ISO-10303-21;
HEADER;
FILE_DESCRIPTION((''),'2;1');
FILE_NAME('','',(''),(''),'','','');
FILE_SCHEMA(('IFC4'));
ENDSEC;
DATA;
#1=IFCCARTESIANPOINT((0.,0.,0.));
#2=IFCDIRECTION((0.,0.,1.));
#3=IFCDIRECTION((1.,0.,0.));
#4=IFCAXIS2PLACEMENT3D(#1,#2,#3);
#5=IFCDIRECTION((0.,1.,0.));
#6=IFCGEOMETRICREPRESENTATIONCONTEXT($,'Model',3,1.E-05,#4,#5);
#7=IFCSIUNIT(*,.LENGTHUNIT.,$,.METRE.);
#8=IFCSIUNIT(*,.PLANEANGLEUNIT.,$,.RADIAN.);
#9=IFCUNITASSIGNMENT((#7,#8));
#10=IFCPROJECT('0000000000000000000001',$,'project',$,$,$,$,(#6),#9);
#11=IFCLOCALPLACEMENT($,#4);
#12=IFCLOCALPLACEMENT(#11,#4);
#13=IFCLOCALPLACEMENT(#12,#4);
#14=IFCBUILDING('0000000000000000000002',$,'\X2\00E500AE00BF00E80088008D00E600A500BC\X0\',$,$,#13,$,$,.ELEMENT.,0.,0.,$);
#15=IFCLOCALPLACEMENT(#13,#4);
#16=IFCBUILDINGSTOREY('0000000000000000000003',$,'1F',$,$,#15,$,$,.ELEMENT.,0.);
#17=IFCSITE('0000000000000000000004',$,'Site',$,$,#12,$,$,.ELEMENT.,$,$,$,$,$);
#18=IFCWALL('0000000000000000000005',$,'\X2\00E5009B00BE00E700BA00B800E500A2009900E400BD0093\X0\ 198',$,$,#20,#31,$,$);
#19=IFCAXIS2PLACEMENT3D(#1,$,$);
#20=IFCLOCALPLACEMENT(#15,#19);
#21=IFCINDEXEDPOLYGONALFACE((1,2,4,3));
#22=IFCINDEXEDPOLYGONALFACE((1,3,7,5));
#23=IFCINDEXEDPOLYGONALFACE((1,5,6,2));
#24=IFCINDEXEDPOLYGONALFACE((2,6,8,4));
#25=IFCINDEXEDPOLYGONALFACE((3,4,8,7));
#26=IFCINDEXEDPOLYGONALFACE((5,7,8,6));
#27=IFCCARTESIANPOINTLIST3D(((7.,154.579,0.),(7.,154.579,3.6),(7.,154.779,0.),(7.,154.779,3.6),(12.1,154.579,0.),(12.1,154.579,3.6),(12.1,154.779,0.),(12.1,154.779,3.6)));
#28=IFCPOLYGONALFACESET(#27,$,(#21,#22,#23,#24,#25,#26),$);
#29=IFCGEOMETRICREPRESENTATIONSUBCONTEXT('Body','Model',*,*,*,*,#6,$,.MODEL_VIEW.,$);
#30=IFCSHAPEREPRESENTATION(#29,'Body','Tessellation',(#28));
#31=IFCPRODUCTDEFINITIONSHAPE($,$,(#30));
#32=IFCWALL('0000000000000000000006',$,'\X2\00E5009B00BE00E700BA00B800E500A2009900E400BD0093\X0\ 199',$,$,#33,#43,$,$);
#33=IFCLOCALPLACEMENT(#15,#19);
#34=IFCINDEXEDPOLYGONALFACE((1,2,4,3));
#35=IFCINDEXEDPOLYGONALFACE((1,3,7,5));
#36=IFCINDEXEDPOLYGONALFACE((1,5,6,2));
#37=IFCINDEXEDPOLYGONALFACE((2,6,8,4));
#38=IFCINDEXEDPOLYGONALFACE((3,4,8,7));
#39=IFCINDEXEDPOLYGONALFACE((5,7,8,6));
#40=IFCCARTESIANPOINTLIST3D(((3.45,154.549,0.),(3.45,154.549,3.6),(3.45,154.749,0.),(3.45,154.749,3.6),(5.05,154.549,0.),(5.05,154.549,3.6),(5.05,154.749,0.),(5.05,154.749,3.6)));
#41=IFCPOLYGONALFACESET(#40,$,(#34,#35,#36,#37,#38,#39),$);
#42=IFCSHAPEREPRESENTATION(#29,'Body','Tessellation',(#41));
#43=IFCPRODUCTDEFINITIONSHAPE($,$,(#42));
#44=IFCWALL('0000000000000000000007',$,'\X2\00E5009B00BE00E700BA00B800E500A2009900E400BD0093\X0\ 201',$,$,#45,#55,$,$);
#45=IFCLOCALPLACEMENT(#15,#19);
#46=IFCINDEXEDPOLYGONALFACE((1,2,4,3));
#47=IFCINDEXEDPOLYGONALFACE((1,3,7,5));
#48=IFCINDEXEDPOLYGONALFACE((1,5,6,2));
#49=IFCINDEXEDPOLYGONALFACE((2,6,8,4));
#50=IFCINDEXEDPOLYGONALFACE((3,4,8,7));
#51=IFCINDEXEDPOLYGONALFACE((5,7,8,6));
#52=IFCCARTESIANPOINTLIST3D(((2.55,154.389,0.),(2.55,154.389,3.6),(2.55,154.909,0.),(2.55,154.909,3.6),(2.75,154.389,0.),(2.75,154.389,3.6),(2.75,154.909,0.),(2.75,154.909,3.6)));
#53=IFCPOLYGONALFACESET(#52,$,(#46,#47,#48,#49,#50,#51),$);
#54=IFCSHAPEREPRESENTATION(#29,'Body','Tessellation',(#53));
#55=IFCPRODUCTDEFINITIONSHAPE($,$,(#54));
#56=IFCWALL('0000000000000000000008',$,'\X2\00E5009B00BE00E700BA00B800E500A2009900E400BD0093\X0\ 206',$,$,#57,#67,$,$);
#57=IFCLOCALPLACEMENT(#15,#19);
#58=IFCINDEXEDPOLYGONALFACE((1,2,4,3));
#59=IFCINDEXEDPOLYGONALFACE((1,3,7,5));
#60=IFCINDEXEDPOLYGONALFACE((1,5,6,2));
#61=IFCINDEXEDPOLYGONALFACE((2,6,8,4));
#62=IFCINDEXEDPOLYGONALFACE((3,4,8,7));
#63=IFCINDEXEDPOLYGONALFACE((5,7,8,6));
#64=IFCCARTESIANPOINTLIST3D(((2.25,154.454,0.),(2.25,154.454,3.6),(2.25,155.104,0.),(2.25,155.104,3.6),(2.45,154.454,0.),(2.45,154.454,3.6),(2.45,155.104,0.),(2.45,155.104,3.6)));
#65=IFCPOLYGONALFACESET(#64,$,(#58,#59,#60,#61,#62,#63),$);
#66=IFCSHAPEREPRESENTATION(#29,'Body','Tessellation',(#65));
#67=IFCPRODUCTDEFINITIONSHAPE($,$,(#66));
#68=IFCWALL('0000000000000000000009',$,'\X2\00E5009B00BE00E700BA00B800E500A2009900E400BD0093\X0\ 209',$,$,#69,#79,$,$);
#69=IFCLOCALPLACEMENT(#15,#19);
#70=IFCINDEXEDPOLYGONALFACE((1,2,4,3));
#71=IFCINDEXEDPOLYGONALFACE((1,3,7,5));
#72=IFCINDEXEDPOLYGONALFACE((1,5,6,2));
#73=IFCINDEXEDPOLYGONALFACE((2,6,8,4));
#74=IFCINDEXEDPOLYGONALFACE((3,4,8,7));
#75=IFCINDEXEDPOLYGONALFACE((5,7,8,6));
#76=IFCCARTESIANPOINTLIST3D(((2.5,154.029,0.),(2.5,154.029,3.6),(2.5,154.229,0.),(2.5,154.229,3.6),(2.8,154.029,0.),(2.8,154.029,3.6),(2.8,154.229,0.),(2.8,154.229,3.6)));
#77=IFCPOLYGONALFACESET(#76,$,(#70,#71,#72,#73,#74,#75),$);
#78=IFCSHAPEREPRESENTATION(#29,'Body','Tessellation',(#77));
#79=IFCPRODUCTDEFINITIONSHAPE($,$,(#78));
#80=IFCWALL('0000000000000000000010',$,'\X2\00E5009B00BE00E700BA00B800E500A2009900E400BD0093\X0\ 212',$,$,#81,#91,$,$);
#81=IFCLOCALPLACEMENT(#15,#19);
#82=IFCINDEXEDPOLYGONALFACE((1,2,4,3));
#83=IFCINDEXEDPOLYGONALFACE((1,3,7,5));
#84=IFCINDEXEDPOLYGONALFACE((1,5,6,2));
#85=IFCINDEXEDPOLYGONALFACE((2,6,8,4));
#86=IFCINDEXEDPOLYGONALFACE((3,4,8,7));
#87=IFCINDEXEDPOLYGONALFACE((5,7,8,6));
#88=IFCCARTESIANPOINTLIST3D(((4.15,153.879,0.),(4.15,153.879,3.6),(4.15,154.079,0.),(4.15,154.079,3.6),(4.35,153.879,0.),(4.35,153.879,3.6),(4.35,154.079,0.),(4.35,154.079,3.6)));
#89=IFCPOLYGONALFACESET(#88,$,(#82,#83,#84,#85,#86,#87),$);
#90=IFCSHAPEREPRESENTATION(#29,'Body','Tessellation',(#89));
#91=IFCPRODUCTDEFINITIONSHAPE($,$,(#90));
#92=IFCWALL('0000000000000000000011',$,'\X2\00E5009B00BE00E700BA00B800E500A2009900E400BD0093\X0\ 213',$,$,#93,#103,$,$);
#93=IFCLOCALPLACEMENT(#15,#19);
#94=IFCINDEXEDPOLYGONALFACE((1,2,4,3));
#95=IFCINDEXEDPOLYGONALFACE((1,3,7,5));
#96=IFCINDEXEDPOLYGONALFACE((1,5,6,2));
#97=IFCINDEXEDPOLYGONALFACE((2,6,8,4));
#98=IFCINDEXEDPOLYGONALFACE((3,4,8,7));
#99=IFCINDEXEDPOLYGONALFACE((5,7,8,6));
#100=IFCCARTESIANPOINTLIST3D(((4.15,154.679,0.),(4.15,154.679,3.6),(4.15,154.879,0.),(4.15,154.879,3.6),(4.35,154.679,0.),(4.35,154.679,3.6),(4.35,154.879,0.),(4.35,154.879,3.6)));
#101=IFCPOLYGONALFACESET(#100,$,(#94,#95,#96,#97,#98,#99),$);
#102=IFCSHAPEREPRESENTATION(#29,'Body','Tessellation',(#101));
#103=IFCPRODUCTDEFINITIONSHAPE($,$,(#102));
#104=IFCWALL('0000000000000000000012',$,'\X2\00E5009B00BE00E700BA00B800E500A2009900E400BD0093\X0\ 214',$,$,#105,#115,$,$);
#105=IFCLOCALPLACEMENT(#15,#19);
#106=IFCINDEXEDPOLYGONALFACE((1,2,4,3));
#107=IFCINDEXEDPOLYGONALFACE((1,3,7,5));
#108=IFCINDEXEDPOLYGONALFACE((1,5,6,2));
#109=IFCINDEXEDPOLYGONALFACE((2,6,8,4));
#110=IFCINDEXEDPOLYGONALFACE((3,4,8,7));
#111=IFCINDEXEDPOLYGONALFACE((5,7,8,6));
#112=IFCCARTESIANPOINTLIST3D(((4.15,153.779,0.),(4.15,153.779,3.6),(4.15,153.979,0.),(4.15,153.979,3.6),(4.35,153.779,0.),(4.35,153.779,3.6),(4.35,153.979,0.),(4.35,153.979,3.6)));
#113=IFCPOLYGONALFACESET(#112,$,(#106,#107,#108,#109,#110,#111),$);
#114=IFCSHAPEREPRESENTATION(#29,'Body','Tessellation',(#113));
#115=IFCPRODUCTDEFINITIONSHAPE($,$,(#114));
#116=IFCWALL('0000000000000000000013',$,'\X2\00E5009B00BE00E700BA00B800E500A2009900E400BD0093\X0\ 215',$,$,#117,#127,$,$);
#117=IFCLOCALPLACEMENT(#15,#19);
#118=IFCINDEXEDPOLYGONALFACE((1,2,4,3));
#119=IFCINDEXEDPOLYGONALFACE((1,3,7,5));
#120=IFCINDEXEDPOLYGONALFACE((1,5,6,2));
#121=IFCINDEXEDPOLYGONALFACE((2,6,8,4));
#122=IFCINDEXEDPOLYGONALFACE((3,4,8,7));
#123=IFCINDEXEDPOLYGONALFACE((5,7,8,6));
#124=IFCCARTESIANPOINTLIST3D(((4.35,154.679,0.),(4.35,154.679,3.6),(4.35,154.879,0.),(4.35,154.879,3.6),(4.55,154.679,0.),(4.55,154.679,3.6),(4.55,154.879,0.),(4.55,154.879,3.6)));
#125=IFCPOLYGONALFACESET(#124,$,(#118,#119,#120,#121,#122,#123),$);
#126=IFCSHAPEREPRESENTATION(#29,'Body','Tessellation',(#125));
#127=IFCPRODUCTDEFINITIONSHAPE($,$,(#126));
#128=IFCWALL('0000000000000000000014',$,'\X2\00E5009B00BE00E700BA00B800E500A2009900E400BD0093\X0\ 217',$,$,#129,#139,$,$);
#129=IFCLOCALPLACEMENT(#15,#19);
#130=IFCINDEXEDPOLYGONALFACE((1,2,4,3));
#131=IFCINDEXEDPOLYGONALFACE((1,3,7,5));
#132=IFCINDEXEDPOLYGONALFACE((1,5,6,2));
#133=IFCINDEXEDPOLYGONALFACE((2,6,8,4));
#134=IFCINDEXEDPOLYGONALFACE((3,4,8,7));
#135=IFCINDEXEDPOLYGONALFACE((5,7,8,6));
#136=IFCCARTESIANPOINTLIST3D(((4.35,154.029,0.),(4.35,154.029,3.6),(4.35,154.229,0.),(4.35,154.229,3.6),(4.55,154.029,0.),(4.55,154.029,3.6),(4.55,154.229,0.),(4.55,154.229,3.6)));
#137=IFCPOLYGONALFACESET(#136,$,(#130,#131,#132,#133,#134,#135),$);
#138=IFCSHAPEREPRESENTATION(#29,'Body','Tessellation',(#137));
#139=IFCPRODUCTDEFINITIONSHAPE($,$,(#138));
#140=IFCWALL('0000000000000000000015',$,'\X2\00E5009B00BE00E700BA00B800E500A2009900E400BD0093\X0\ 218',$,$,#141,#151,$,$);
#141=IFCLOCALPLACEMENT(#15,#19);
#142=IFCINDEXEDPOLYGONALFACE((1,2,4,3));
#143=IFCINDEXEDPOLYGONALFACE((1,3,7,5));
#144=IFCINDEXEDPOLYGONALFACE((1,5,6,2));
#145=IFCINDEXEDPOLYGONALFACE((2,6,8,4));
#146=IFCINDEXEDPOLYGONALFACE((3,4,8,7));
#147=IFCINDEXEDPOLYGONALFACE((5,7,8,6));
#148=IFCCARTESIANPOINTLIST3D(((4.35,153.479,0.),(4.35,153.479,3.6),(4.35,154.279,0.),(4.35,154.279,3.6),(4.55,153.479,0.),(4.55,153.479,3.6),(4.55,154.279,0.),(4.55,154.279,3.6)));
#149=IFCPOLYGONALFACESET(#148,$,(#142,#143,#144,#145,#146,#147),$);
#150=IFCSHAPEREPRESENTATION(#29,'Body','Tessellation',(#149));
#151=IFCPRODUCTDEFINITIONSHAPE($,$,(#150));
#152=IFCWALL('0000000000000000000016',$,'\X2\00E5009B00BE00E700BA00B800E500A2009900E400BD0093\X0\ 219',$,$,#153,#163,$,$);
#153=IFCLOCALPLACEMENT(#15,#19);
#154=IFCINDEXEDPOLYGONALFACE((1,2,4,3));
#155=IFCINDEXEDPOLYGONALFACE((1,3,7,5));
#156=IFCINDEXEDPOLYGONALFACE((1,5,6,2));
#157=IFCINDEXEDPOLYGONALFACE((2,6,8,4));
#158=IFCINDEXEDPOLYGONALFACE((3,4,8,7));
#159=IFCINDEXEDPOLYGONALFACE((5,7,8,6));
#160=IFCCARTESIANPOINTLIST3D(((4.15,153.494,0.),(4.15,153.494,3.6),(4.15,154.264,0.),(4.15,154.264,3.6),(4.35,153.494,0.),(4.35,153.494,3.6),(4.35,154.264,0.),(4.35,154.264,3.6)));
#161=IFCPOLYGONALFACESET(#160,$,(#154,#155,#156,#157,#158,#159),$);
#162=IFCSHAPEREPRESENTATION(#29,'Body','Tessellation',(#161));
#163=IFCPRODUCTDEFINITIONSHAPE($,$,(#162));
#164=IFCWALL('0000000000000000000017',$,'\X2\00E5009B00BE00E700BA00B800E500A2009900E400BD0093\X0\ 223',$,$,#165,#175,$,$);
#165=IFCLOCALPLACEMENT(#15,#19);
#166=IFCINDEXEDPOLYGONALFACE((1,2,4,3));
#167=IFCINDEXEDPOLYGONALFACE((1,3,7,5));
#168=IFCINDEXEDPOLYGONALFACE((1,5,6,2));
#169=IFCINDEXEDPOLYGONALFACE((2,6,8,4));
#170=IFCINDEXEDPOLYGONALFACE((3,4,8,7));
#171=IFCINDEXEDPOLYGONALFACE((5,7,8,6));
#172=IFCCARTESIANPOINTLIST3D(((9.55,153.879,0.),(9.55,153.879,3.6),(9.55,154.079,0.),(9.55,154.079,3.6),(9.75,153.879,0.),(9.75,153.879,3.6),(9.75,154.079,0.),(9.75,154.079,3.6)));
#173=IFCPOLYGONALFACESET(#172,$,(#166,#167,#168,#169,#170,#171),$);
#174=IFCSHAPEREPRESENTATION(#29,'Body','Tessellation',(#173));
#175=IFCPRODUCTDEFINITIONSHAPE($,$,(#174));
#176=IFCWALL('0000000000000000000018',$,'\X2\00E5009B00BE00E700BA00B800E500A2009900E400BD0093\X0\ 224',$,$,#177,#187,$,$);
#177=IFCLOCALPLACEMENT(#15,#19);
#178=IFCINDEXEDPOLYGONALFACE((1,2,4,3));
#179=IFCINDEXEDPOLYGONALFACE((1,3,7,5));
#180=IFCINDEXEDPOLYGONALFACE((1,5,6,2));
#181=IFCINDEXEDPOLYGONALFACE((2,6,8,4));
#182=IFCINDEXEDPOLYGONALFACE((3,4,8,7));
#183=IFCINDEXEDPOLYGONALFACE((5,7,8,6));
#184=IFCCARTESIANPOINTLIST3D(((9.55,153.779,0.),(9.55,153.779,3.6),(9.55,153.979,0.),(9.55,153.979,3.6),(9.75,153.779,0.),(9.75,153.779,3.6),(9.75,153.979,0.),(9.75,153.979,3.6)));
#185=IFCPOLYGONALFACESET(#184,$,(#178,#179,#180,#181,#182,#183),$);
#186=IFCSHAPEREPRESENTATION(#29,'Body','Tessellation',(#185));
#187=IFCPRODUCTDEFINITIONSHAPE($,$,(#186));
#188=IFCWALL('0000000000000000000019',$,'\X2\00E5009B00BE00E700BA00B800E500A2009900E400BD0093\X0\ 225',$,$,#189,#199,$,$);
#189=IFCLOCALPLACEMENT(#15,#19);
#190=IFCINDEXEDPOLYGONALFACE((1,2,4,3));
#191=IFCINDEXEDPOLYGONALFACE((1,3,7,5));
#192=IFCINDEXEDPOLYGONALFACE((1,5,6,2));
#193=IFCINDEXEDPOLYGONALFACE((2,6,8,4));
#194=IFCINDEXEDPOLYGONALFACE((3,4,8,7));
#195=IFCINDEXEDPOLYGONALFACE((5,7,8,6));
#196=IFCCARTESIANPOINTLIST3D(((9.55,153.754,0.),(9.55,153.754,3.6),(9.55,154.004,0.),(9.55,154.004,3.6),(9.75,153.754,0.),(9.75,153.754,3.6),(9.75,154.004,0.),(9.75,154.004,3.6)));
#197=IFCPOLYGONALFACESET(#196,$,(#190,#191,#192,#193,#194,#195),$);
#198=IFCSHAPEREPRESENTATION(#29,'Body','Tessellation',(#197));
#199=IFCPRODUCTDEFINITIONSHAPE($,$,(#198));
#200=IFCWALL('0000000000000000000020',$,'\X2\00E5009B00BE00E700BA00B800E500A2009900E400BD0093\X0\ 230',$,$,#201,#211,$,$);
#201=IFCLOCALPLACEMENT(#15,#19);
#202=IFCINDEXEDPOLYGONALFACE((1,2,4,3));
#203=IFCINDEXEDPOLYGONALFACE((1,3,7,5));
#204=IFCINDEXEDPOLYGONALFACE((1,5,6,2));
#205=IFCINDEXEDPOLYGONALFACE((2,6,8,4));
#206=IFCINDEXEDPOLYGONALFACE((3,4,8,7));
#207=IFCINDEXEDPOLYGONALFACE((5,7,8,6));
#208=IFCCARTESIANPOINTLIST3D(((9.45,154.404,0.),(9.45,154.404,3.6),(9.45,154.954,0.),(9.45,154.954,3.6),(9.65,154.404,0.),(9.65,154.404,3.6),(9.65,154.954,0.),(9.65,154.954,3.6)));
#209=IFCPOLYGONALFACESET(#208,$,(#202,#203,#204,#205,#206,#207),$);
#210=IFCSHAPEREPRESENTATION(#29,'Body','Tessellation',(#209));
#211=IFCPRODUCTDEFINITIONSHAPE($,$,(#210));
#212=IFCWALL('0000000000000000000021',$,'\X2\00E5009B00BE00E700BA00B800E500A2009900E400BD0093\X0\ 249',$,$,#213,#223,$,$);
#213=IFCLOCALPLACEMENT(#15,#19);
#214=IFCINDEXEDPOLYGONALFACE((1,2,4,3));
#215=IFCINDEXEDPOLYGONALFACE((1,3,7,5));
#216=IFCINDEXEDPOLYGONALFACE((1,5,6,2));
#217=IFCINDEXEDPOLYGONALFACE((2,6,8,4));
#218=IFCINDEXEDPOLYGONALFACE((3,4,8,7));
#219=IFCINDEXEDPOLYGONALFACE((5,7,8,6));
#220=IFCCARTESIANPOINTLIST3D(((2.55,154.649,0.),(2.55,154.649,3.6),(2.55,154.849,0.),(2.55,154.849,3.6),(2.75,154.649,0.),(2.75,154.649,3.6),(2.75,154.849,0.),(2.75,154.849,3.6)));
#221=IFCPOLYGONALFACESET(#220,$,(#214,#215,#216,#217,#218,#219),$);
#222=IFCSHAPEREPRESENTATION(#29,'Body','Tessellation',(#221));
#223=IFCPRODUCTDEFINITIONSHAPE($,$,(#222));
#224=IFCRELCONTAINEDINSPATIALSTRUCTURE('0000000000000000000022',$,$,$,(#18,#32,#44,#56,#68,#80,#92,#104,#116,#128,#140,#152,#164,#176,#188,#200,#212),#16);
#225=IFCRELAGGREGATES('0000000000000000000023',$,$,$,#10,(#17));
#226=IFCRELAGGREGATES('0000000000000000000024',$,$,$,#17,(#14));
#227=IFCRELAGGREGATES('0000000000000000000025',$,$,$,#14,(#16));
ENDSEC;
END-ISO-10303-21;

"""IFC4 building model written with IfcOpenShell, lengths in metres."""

from ifc_helpers import new_model, si_unit, direction, frame, frame_2d, origin_with_axes, place, context, subcontext, project, spatial, rectangle, extrude, element, save


model = new_model("IFC4")

# Units and contexts
model_context = context("Model", 3, precision=1e-05, world=origin_with_axes(), true_north=direction((0.0, 1.0, 0.0)))
body_context = subcontext(model_context, "Body", "Model", "MODEL_VIEW")
ifc_project = project(units=[si_unit("LENGTHUNIT", "METRE"), si_unit("PLANEANGLEUNIT", "RADIAN")], contexts=[model_context])

# Site, building, storey
placement = place(None, origin_with_axes())
site_placement = place(placement, origin_with_axes())
site = spatial("IfcSite", under=ifc_project, at=site_placement, Name="Site", CompositionType="ELEMENT")
building_placement = place(site_placement, origin_with_axes())
building = spatial("IfcBuilding", under=site, at=building_placement, Name="å®¿è\u0088\u008dæ¥¼", CompositionType="ELEMENT", ElevationOfRefHeight=0.0, ElevationOfTerrain=0.0)
storey_placement = place(building_placement, origin_with_axes())
storey = spatial("IfcBuildingStorey", under=building, at=storey_placement, Name="1F", CompositionType="ELEMENT", Elevation=0.0)

# Walls
wall_1_placement = place(storey_placement, frame((9.55, 154.679, 0.0), z_axis=(0.0, 0.0, 1.0), x_axis=(-1.0, 0.0, 0.0)))
element("IfcWall", 1, at=wall_1_placement, inside=storey, Name="å\u009b¾çº¸å¢\u0099ä½\u0093 198", context=body_context, shape_type="SweptSolid", body=[
    extrude(rectangle(XDim=5.1, YDim=0.2, at=frame_2d((0.0, 0.0), x_axis=(1.0, 0.0, 0.0))), frame((0.0, 0.0, 0.0), z_axis=(0.0, 0.0, 1.0)), (0.0, 0.0, 1.0), 3.6),
])
wall_2_placement = place(storey_placement, frame((4.25, 154.649, 0.0), z_axis=(0.0, 0.0, 1.0), x_axis=(-1.0, 0.0, 0.0)))
element("IfcWall", 2, at=wall_2_placement, inside=storey, Name="å\u009b¾çº¸å¢\u0099ä½\u0093 199", context=body_context, shape_type="SweptSolid", body=[
    extrude(rectangle(XDim=1.6, YDim=0.2, at=frame_2d((0.0, 0.0), x_axis=(1.0, 0.0, 0.0))), frame((0.0, 0.0, 0.0), z_axis=(0.0, 0.0, 1.0)), (0.0, 0.0, 1.0), 3.6),
])
wall_3_placement = place(storey_placement, frame((2.65, 154.649, 0.0), z_axis=(0.0, 0.0, 1.0), x_axis=(0.0, -1.0, 0.0)))
element("IfcWall", 3, at=wall_3_placement, inside=storey, Name="å\u009b¾çº¸å¢\u0099ä½\u0093 201", context=body_context, shape_type="SweptSolid", body=[
    extrude(rectangle(XDim=0.52, YDim=0.2, at=frame_2d((0.0, 0.0), x_axis=(1.0, 0.0, 0.0))), frame((0.0, 0.0, 0.0), z_axis=(0.0, 0.0, 1.0)), (0.0, 0.0, 1.0), 3.6),
])
wall_4_placement = place(storey_placement, frame((2.35, 154.779, 0.0), z_axis=(0.0, 0.0, 1.0), x_axis=(0.0, -1.0, 0.0)))
element("IfcWall", 4, at=wall_4_placement, inside=storey, Name="å\u009b¾çº¸å¢\u0099ä½\u0093 206", context=body_context, shape_type="SweptSolid", body=[
    extrude(rectangle(XDim=0.65, YDim=0.2, at=frame_2d((0.0, 0.0), x_axis=(1.0, 0.0, 0.0))), frame((0.0, 0.0, 0.0), z_axis=(0.0, 0.0, 1.0)), (0.0, 0.0, 1.0), 3.6),
])
wall_5_placement = place(storey_placement, frame((2.65, 154.129, 0.0), z_axis=(0.0, 0.0, 1.0), x_axis=(-1.0, 0.0, 0.0)))
element("IfcWall", 5, at=wall_5_placement, inside=storey, Name="å\u009b¾çº¸å¢\u0099ä½\u0093 209", context=body_context, shape_type="SweptSolid", body=[
    extrude(rectangle(XDim=0.3, YDim=0.2, at=frame_2d((0.0, 0.0), x_axis=(1.0, 0.0, 0.0))), frame((0.0, 0.0, 0.0), z_axis=(0.0, 0.0, 1.0)), (0.0, 0.0, 1.0), 3.6),
])
for number, where, z_axis, x_axis, name in (
    (6, (4.25, 153.979, 0.0), (0.0, 0.0, 1.0), (1.0, 0.0, 0.0), "å\u009b¾çº¸å¢\u0099ä½\u0093 212"),
    (7, (4.25, 154.779, 0.0), (0.0, 0.0, 1.0), (1.0, 0.0, 0.0), "å\u009b¾çº¸å¢\u0099ä½\u0093 213"),
    (8, (4.25, 153.879, 0.0), (0.0, 0.0, 1.0), (1.0, 0.0, 0.0), "å\u009b¾çº¸å¢\u0099ä½\u0093 214"),
    (9, (4.45, 154.779, 0.0), (0.0, 0.0, 1.0), (-1.0, 0.0, 0.0), "å\u009b¾çº¸å¢\u0099ä½\u0093 215"),
    (10, (4.45, 154.129, 0.0), (0.0, 0.0, 1.0), (-1.0, 0.0, 0.0), "å\u009b¾çº¸å¢\u0099ä½\u0093 217"),
):
    element("IfcWall", number, at=place(storey_placement, frame(where, z_axis=z_axis, x_axis=x_axis)), inside=storey, Name=name, context=body_context, shape_type="SweptSolid", body=[
        extrude(rectangle(XDim=0.2, YDim=0.2, at=frame_2d((0.0, 0.0), x_axis=(1.0, 0.0, 0.0))), frame((0.0, 0.0, 0.0), z_axis=(0.0, 0.0, 1.0)), (0.0, 0.0, 1.0), 3.6),
    ])
wall_6_placement = place(storey_placement, frame((4.45, 153.879, 0.0), z_axis=(0.0, 0.0, 1.0), x_axis=(0.0, 1.0, 0.0)))
element("IfcWall", 11, at=wall_6_placement, inside=storey, Name="å\u009b¾çº¸å¢\u0099ä½\u0093 218", context=body_context, shape_type="SweptSolid", body=[
    extrude(rectangle(XDim=0.8, YDim=0.2, at=frame_2d((0.0, 0.0), x_axis=(1.0, 0.0, 0.0))), frame((0.0, 0.0, 0.0), z_axis=(0.0, 0.0, 1.0)), (0.0, 0.0, 1.0), 3.6),
])
wall_7_placement = place(storey_placement, frame((4.25, 153.879, 0.0), z_axis=(0.0, 0.0, 1.0), x_axis=(0.0, 1.0, 0.0)))
element("IfcWall", 12, at=wall_7_placement, inside=storey, Name="å\u009b¾çº¸å¢\u0099ä½\u0093 219", context=body_context, shape_type="SweptSolid", body=[
    extrude(rectangle(XDim=0.77, YDim=0.2, at=frame_2d((0.0, 0.0), x_axis=(1.0, 0.0, 0.0))), frame((0.0, 0.0, 0.0), z_axis=(0.0, 0.0, 1.0)), (0.0, 0.0, 1.0), 3.6),
])
for number, where, z_axis, x_axis, name in (
    (13, (9.65, 153.979, 0.0), (0.0, 0.0, 1.0), (1.0, 0.0, 0.0), "å\u009b¾çº¸å¢\u0099ä½\u0093 223"),
    (14, (9.65, 153.879, 0.0), (0.0, 0.0, 1.0), (1.0, 0.0, 0.0), "å\u009b¾çº¸å¢\u0099ä½\u0093 224"),
):
    element("IfcWall", number, at=place(storey_placement, frame(where, z_axis=z_axis, x_axis=x_axis)), inside=storey, Name=name, context=body_context, shape_type="SweptSolid", body=[
        extrude(rectangle(XDim=0.2, YDim=0.2, at=frame_2d((0.0, 0.0), x_axis=(1.0, 0.0, 0.0))), frame((0.0, 0.0, 0.0), z_axis=(0.0, 0.0, 1.0)), (0.0, 0.0, 1.0), 3.6),
    ])
wall_8_placement = place(storey_placement, frame((9.65, 153.879, 0.0), z_axis=(0.0, 0.0, 1.0), x_axis=(0.0, 1.0, 0.0)))
element("IfcWall", 15, at=wall_8_placement, inside=storey, Name="å\u009b¾çº¸å¢\u0099ä½\u0093 225", context=body_context, shape_type="SweptSolid", body=[
    extrude(rectangle(XDim=0.25, YDim=0.2, at=frame_2d((0.0, 0.0), x_axis=(1.0, 0.0, 0.0))), frame((0.0, 0.0, 0.0), z_axis=(0.0, 0.0, 1.0)), (0.0, 0.0, 1.0), 3.6),
])
wall_9_placement = place(storey_placement, frame((9.55, 154.679, 0.0), z_axis=(0.0, 0.0, 1.0), x_axis=(0.0, -1.0, 0.0)))
element("IfcWall", 16, at=wall_9_placement, inside=storey, Name="å\u009b¾çº¸å¢\u0099ä½\u0093 230", context=body_context, shape_type="SweptSolid", body=[
    extrude(rectangle(XDim=0.55, YDim=0.2, at=frame_2d((0.0, 0.0), x_axis=(1.0, 0.0, 0.0))), frame((0.0, 0.0, 0.0), z_axis=(0.0, 0.0, 1.0)), (0.0, 0.0, 1.0), 3.6),
])
for number, where, z_axis, x_axis, name in (
    (17, (2.65, 154.749, 0.0), (0.0, 0.0, 1.0), (0.0, 1.0, 0.0), "å\u009b¾çº¸å¢\u0099ä½\u0093 249"),
):
    element("IfcWall", number, at=place(storey_placement, frame(where, z_axis=z_axis, x_axis=x_axis)), inside=storey, Name=name, context=body_context, shape_type="SweptSolid", body=[
        extrude(rectangle(XDim=0.2, YDim=0.2, at=frame_2d((0.0, 0.0), x_axis=(1.0, 0.0, 0.0))), frame((0.0, 0.0, 0.0), z_axis=(0.0, 0.0, 1.0)), (0.0, 0.0, 1.0), 3.6),
    ])

save(model, "model.ifc")
